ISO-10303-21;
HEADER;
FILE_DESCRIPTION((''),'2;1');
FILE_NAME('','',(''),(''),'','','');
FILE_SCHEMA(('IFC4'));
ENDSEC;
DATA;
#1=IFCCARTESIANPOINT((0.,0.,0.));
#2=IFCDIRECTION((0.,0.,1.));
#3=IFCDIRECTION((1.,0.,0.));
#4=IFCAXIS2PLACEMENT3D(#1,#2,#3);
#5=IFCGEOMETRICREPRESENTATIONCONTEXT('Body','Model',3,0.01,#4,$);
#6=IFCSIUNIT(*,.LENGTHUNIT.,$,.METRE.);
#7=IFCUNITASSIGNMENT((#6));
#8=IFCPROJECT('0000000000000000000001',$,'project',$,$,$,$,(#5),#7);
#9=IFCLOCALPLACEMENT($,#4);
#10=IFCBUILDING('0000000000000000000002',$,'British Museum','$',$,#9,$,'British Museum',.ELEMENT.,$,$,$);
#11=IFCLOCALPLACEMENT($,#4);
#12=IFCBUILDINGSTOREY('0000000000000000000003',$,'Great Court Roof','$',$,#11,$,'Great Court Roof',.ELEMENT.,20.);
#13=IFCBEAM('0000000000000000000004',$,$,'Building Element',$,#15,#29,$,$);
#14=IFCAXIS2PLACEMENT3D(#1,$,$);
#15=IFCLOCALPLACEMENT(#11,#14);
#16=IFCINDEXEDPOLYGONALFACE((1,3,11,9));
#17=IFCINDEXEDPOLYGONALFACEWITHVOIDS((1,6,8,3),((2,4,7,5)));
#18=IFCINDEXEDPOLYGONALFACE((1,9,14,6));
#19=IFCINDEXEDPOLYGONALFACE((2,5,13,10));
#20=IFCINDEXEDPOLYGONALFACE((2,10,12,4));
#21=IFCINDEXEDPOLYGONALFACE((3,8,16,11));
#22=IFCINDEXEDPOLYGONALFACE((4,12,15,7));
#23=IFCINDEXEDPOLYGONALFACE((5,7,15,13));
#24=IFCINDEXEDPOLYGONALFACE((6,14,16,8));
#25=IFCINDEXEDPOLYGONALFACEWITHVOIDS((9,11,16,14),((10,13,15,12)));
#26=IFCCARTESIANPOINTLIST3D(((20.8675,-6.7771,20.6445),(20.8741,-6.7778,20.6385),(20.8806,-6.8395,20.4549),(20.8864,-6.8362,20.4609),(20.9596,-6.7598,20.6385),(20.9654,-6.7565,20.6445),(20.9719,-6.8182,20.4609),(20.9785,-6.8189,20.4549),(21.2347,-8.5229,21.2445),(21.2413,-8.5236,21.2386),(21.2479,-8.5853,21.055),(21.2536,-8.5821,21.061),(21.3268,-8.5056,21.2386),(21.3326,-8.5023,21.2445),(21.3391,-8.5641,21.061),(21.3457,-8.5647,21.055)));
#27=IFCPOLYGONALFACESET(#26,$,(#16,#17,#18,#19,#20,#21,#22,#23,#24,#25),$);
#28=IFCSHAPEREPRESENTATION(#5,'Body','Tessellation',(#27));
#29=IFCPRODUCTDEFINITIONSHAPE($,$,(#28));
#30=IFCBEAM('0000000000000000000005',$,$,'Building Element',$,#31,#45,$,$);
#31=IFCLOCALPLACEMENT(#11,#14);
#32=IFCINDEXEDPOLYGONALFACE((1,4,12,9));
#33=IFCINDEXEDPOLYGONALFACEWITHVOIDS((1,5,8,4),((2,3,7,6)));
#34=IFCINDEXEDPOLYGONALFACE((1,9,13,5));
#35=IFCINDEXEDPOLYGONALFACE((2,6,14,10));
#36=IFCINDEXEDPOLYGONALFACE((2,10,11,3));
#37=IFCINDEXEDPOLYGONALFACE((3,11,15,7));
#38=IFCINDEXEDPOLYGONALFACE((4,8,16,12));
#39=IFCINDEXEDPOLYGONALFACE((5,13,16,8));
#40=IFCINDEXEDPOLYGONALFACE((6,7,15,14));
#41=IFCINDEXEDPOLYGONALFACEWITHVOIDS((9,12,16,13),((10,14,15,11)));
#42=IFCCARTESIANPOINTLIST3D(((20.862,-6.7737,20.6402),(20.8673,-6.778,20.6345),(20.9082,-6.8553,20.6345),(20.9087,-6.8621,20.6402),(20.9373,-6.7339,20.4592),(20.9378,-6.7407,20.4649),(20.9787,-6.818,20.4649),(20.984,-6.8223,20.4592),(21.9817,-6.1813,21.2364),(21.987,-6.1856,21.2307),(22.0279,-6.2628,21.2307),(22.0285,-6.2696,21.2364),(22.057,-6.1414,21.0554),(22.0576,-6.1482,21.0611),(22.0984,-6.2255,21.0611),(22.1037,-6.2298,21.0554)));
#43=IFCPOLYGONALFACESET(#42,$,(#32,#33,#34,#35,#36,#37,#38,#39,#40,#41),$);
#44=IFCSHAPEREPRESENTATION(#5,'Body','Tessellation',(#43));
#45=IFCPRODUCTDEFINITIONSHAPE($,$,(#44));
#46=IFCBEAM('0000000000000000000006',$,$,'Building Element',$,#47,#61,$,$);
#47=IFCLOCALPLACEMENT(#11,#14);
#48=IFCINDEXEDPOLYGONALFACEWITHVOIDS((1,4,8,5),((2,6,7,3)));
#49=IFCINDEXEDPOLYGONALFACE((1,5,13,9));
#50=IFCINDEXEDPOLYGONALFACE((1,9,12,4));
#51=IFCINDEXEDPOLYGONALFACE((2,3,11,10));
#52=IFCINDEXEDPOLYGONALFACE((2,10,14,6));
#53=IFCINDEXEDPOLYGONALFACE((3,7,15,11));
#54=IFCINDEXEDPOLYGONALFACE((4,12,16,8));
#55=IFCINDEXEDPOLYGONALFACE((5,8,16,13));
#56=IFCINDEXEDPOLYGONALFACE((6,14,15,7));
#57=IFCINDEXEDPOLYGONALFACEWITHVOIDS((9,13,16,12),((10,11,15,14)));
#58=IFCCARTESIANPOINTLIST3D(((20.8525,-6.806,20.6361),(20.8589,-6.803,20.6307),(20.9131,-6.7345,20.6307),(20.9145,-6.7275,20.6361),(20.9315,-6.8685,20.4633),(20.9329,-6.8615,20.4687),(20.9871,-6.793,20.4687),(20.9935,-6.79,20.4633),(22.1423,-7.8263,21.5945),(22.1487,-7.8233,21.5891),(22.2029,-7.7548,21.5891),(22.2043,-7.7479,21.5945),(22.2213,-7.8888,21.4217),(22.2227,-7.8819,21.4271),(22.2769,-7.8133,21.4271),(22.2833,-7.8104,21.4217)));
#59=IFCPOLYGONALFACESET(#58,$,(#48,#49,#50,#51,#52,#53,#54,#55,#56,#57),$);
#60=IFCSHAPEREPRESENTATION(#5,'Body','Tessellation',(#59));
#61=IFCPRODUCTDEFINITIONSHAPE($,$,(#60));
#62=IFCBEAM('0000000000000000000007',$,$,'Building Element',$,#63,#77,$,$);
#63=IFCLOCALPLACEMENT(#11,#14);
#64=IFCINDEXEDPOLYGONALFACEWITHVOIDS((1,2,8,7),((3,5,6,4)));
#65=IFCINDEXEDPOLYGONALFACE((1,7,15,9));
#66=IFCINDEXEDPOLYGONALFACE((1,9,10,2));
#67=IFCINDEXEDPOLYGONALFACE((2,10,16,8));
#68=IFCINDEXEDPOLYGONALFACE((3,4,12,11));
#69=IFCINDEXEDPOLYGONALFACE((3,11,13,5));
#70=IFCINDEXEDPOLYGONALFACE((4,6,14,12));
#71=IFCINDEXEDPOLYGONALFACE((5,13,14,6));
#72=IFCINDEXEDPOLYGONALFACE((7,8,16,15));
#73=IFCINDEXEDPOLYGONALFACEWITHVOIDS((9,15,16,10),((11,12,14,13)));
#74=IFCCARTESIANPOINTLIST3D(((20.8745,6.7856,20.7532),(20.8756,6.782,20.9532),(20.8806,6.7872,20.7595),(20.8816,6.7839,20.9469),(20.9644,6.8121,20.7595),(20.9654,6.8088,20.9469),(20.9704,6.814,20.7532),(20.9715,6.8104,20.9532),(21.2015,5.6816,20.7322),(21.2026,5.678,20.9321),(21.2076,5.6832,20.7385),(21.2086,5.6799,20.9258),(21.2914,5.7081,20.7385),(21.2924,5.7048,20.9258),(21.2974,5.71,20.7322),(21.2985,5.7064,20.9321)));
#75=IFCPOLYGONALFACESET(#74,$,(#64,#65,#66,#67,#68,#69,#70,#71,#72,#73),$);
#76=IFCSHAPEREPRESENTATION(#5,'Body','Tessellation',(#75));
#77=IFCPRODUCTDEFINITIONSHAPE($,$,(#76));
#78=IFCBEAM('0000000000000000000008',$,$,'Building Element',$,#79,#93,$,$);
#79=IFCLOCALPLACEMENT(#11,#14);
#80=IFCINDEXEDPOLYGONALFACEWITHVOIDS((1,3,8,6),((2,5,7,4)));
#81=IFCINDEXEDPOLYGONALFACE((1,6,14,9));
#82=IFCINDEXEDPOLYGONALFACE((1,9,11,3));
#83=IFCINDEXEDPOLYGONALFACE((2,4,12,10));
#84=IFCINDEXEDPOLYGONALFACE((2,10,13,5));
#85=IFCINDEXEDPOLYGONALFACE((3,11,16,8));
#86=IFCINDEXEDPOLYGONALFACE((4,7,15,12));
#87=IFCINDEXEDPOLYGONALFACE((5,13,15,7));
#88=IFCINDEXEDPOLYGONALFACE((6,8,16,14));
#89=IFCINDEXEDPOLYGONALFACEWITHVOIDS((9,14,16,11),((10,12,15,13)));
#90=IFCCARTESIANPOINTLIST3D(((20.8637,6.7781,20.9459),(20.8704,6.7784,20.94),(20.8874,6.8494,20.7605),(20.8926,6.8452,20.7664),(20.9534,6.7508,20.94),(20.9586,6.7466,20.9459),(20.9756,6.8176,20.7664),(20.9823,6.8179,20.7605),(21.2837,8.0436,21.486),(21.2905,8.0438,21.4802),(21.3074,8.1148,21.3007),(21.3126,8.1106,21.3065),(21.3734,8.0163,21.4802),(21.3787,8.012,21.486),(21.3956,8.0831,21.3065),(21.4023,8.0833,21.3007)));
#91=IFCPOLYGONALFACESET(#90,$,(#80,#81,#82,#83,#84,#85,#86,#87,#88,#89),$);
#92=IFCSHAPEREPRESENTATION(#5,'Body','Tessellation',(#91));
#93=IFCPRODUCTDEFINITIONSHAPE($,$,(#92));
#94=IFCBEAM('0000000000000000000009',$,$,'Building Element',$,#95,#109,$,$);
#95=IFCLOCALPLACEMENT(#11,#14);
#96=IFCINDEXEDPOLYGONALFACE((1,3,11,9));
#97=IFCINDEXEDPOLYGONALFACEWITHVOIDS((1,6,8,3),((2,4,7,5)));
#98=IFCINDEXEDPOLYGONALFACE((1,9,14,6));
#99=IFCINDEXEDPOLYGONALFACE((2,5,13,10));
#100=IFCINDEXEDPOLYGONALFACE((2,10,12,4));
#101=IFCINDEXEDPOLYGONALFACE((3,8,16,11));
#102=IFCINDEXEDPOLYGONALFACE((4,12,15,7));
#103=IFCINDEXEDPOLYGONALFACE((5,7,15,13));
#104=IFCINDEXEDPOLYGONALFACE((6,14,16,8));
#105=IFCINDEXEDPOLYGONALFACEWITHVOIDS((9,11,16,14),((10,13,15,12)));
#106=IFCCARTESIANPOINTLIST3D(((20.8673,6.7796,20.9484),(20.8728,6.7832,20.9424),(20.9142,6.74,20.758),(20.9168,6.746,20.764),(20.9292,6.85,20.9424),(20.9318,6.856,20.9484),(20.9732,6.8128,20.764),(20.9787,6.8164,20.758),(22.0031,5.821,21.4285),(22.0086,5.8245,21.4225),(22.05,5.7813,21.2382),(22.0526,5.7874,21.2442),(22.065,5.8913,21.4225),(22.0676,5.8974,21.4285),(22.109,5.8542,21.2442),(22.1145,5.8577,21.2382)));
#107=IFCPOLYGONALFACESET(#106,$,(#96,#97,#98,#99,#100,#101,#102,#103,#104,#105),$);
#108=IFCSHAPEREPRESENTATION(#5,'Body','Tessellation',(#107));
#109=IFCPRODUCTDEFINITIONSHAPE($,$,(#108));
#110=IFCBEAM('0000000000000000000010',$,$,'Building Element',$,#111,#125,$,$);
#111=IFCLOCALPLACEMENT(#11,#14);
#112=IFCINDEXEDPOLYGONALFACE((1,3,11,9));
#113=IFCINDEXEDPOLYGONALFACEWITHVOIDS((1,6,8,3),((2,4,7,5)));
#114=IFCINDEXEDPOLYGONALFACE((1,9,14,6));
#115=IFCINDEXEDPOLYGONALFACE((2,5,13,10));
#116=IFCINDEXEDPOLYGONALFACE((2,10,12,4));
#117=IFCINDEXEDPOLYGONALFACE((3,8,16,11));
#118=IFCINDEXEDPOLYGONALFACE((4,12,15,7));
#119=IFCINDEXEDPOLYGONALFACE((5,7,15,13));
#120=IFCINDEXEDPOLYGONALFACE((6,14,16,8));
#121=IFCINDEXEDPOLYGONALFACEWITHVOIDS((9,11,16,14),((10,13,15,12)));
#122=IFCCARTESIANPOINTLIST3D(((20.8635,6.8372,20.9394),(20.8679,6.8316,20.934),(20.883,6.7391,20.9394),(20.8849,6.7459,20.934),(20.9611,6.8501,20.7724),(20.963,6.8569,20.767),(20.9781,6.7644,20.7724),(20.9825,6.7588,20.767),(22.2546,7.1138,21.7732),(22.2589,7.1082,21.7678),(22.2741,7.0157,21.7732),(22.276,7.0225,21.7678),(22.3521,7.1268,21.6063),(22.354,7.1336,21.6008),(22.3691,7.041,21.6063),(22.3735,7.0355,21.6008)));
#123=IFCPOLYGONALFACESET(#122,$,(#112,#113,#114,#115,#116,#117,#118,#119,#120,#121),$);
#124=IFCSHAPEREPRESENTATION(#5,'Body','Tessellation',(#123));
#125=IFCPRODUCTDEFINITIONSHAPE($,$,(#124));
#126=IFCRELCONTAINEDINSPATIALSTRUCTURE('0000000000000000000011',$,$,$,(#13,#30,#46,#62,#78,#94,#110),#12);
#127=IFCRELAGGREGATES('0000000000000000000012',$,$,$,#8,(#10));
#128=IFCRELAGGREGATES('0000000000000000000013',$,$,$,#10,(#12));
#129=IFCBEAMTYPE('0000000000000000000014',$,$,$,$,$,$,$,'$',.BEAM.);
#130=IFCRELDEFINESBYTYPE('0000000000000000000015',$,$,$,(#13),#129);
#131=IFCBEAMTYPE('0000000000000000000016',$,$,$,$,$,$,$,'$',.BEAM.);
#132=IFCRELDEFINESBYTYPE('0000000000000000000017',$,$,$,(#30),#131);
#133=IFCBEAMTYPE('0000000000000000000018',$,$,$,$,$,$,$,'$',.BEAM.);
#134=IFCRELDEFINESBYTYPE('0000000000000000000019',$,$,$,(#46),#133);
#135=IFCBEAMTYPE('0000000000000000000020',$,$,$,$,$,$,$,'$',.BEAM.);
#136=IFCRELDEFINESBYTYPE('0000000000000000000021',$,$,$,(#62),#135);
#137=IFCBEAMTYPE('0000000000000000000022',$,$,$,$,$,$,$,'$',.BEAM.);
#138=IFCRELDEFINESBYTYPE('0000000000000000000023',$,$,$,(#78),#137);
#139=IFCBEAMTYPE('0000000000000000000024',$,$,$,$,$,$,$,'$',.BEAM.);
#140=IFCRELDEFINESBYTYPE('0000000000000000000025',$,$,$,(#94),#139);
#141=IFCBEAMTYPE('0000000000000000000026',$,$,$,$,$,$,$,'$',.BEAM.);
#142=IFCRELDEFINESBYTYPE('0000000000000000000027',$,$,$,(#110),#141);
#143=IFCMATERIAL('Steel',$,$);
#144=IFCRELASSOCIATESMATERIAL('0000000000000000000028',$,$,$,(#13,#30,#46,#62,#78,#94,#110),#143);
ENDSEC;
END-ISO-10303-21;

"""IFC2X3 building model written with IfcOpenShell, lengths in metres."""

from ifc_helpers import new_model, si_unit, frame, origin_with_axes, origin_2d, place, context, project, spatial, hollow_rectangle, extrude, material, type_object, element, save


model = new_model("IFC2X3")

# Units and contexts
model_context = context("Model", 3, precision=0.01, world=origin_with_axes(), identifier="Body")
ifc_project = project(units=[si_unit("LENGTHUNIT", "METRE")], contexts=[model_context])

# Building, storey
building_placement = place(None, origin_with_axes())
building = spatial("IfcBuilding", under=ifc_project, at=building_placement, Name="British Museum", Description="$", LongName="British Museum", CompositionType="ELEMENT")
storey_placement = place(None, origin_with_axes())
storey = spatial("IfcBuildingStorey", under=building, at=storey_placement, Name="Great Court Roof", Description="$", LongName="Great Court Roof", CompositionType="ELEMENT", Elevation=20.0)

# Beams
ifc_material = material(Name="Steel")
beam_type_1 = type_object("IfcBeamType", ElementType="$", PredefinedType="BEAM")
beam_1_placement = place(None, origin_with_axes())
element("IfcBeam", 1, at=beam_1_placement, inside=storey, type_object=beam_type_1, material=ifc_material, Description="Building Element", context=model_context, shape_type="SweptSolid", body=[
    extrude(hollow_rectangle(XDim=0.1, YDim=0.2, WallThickness=0.0063, InnerFilletRadius=0.0, OuterFilletRadius=0.0, at=origin_2d()), frame((20.923, -6.798, 20.5497), z_axis=(0.195098, -0.927526, 0.318799), x_axis=(0.978586, 0.205838, 0.0)), (0.0, 0.0, 1.0), 1.8823),
])
beam_type_2 = type_object("IfcBeamType", ElementType="$", PredefinedType="BEAM")
beam_2_placement = place(None, origin_with_axes())
element("IfcBeam", 2, at=beam_2_placement, inside=storey, type_object=beam_type_2, material=ifc_material, Description="Building Element", context=model_context, shape_type="SweptSolid", body=[
    extrude(hollow_rectangle(XDim=0.1, YDim=0.2, WallThickness=0.0063, InnerFilletRadius=0.0, OuterFilletRadius=0.0, at=origin_2d()), frame((20.923, -6.798, 20.5497), z_axis=(0.799754, 0.423164, 0.425823), x_axis=(-0.467685, 0.883895, 0.0)), (0.0, 0.0, 1.0), 1.4001),
])
beam_type_3 = type_object("IfcBeamType", ElementType="$", PredefinedType="BEAM")
beam_3_placement = place(None, origin_with_axes())
element("IfcBeam", 3, at=beam_3_placement, inside=storey, type_object=beam_type_3, material=ifc_material, Description="Building Element", context=model_context, shape_type="SweptSolid", body=[
    extrude(hollow_rectangle(XDim=0.1, YDim=0.2, WallThickness=0.0063, InnerFilletRadius=0.0, OuterFilletRadius=0.0, at=origin_2d()), frame((20.923, -6.798, 20.5497), z_axis=(0.677604, -0.536043, 0.503499), x_axis=(0.620423, 0.784268, 0.0)), (0.0, 0.0, 1.0), 1.9035),
])
beam_type_4 = type_object("IfcBeamType", ElementType="$", PredefinedType="BEAM")
beam_4_placement = place(None, origin_with_axes())
element("IfcBeam", 4, at=beam_4_placement, inside=storey, type_object=beam_type_4, material=ifc_material, Description="Building Element", context=model_context, shape_type="SweptSolid", body=[
    extrude(hollow_rectangle(XDim=0.1, YDim=0.2, WallThickness=0.0063, InnerFilletRadius=0.0, OuterFilletRadius=0.0, at=origin_2d()), frame((20.923, 6.798, 20.8532), z_axis=(0.283952, -0.958664, -0.018263), x_axis=(0.958824, 0.284, 0.0)), (0.0, 0.0, 1.0), 1.1516),
])
beam_type_5 = type_object("IfcBeamType", ElementType="$", PredefinedType="BEAM")
beam_5_placement = place(None, origin_with_axes())
element("IfcBeam", 5, at=beam_5_placement, inside=storey, type_object=beam_type_5, material=ifc_material, Description="Building Element", context=model_context, shape_type="SweptSolid", body=[
    extrude(hollow_rectangle(XDim=0.1, YDim=0.2, WallThickness=0.0063, InnerFilletRadius=0.0, OuterFilletRadius=0.0, at=origin_2d()), frame((20.923, 6.798, 20.8532), z_axis=(0.291971, 0.879638, 0.375486), x_axis=(-0.949085, 0.315021, 0.0)), (0.0, 0.0, 1.0), 1.4386),
])
beam_type_6 = type_object("IfcBeamType", ElementType="$", PredefinedType="BEAM")
beam_6_placement = place(None, origin_with_axes())
element("IfcBeam", 6, at=beam_6_placement, inside=storey, type_object=beam_type_6, material=ifc_material, Description="Building Element", context=model_context, shape_type="SweptSolid", body=[
    extrude(hollow_rectangle(XDim=0.1, YDim=0.2, WallThickness=0.0063, InnerFilletRadius=0.0, OuterFilletRadius=0.0, at=origin_2d()), frame((20.923, 6.798, 20.8532), z_axis=(0.72718, -0.613761, 0.307419), x_axis=(0.644995, 0.764187, 0.0)), (0.0, 0.0, 1.0), 1.5619),
])
beam_type_7 = type_object("IfcBeamType", ElementType="$", PredefinedType="BEAM")
beam_7_placement = place(None, origin_with_axes())
element("IfcBeam", 7, at=beam_7_placement, inside=storey, type_object=beam_type_7, material=ifc_material, Description="Building Element", context=model_context, shape_type="SweptSolid", body=[
    extrude(hollow_rectangle(XDim=0.1, YDim=0.2, WallThickness=0.0063, InnerFilletRadius=0.0, OuterFilletRadius=0.0, at=origin_2d()), frame((20.923, 6.798, 20.8532), z_axis=(0.845491, 0.16815, 0.506824), x_axis=(-0.195058, 0.980792, 0.0)), (0.0, 0.0, 1.0), 1.6452),
])

save(model, "model.ifc")
